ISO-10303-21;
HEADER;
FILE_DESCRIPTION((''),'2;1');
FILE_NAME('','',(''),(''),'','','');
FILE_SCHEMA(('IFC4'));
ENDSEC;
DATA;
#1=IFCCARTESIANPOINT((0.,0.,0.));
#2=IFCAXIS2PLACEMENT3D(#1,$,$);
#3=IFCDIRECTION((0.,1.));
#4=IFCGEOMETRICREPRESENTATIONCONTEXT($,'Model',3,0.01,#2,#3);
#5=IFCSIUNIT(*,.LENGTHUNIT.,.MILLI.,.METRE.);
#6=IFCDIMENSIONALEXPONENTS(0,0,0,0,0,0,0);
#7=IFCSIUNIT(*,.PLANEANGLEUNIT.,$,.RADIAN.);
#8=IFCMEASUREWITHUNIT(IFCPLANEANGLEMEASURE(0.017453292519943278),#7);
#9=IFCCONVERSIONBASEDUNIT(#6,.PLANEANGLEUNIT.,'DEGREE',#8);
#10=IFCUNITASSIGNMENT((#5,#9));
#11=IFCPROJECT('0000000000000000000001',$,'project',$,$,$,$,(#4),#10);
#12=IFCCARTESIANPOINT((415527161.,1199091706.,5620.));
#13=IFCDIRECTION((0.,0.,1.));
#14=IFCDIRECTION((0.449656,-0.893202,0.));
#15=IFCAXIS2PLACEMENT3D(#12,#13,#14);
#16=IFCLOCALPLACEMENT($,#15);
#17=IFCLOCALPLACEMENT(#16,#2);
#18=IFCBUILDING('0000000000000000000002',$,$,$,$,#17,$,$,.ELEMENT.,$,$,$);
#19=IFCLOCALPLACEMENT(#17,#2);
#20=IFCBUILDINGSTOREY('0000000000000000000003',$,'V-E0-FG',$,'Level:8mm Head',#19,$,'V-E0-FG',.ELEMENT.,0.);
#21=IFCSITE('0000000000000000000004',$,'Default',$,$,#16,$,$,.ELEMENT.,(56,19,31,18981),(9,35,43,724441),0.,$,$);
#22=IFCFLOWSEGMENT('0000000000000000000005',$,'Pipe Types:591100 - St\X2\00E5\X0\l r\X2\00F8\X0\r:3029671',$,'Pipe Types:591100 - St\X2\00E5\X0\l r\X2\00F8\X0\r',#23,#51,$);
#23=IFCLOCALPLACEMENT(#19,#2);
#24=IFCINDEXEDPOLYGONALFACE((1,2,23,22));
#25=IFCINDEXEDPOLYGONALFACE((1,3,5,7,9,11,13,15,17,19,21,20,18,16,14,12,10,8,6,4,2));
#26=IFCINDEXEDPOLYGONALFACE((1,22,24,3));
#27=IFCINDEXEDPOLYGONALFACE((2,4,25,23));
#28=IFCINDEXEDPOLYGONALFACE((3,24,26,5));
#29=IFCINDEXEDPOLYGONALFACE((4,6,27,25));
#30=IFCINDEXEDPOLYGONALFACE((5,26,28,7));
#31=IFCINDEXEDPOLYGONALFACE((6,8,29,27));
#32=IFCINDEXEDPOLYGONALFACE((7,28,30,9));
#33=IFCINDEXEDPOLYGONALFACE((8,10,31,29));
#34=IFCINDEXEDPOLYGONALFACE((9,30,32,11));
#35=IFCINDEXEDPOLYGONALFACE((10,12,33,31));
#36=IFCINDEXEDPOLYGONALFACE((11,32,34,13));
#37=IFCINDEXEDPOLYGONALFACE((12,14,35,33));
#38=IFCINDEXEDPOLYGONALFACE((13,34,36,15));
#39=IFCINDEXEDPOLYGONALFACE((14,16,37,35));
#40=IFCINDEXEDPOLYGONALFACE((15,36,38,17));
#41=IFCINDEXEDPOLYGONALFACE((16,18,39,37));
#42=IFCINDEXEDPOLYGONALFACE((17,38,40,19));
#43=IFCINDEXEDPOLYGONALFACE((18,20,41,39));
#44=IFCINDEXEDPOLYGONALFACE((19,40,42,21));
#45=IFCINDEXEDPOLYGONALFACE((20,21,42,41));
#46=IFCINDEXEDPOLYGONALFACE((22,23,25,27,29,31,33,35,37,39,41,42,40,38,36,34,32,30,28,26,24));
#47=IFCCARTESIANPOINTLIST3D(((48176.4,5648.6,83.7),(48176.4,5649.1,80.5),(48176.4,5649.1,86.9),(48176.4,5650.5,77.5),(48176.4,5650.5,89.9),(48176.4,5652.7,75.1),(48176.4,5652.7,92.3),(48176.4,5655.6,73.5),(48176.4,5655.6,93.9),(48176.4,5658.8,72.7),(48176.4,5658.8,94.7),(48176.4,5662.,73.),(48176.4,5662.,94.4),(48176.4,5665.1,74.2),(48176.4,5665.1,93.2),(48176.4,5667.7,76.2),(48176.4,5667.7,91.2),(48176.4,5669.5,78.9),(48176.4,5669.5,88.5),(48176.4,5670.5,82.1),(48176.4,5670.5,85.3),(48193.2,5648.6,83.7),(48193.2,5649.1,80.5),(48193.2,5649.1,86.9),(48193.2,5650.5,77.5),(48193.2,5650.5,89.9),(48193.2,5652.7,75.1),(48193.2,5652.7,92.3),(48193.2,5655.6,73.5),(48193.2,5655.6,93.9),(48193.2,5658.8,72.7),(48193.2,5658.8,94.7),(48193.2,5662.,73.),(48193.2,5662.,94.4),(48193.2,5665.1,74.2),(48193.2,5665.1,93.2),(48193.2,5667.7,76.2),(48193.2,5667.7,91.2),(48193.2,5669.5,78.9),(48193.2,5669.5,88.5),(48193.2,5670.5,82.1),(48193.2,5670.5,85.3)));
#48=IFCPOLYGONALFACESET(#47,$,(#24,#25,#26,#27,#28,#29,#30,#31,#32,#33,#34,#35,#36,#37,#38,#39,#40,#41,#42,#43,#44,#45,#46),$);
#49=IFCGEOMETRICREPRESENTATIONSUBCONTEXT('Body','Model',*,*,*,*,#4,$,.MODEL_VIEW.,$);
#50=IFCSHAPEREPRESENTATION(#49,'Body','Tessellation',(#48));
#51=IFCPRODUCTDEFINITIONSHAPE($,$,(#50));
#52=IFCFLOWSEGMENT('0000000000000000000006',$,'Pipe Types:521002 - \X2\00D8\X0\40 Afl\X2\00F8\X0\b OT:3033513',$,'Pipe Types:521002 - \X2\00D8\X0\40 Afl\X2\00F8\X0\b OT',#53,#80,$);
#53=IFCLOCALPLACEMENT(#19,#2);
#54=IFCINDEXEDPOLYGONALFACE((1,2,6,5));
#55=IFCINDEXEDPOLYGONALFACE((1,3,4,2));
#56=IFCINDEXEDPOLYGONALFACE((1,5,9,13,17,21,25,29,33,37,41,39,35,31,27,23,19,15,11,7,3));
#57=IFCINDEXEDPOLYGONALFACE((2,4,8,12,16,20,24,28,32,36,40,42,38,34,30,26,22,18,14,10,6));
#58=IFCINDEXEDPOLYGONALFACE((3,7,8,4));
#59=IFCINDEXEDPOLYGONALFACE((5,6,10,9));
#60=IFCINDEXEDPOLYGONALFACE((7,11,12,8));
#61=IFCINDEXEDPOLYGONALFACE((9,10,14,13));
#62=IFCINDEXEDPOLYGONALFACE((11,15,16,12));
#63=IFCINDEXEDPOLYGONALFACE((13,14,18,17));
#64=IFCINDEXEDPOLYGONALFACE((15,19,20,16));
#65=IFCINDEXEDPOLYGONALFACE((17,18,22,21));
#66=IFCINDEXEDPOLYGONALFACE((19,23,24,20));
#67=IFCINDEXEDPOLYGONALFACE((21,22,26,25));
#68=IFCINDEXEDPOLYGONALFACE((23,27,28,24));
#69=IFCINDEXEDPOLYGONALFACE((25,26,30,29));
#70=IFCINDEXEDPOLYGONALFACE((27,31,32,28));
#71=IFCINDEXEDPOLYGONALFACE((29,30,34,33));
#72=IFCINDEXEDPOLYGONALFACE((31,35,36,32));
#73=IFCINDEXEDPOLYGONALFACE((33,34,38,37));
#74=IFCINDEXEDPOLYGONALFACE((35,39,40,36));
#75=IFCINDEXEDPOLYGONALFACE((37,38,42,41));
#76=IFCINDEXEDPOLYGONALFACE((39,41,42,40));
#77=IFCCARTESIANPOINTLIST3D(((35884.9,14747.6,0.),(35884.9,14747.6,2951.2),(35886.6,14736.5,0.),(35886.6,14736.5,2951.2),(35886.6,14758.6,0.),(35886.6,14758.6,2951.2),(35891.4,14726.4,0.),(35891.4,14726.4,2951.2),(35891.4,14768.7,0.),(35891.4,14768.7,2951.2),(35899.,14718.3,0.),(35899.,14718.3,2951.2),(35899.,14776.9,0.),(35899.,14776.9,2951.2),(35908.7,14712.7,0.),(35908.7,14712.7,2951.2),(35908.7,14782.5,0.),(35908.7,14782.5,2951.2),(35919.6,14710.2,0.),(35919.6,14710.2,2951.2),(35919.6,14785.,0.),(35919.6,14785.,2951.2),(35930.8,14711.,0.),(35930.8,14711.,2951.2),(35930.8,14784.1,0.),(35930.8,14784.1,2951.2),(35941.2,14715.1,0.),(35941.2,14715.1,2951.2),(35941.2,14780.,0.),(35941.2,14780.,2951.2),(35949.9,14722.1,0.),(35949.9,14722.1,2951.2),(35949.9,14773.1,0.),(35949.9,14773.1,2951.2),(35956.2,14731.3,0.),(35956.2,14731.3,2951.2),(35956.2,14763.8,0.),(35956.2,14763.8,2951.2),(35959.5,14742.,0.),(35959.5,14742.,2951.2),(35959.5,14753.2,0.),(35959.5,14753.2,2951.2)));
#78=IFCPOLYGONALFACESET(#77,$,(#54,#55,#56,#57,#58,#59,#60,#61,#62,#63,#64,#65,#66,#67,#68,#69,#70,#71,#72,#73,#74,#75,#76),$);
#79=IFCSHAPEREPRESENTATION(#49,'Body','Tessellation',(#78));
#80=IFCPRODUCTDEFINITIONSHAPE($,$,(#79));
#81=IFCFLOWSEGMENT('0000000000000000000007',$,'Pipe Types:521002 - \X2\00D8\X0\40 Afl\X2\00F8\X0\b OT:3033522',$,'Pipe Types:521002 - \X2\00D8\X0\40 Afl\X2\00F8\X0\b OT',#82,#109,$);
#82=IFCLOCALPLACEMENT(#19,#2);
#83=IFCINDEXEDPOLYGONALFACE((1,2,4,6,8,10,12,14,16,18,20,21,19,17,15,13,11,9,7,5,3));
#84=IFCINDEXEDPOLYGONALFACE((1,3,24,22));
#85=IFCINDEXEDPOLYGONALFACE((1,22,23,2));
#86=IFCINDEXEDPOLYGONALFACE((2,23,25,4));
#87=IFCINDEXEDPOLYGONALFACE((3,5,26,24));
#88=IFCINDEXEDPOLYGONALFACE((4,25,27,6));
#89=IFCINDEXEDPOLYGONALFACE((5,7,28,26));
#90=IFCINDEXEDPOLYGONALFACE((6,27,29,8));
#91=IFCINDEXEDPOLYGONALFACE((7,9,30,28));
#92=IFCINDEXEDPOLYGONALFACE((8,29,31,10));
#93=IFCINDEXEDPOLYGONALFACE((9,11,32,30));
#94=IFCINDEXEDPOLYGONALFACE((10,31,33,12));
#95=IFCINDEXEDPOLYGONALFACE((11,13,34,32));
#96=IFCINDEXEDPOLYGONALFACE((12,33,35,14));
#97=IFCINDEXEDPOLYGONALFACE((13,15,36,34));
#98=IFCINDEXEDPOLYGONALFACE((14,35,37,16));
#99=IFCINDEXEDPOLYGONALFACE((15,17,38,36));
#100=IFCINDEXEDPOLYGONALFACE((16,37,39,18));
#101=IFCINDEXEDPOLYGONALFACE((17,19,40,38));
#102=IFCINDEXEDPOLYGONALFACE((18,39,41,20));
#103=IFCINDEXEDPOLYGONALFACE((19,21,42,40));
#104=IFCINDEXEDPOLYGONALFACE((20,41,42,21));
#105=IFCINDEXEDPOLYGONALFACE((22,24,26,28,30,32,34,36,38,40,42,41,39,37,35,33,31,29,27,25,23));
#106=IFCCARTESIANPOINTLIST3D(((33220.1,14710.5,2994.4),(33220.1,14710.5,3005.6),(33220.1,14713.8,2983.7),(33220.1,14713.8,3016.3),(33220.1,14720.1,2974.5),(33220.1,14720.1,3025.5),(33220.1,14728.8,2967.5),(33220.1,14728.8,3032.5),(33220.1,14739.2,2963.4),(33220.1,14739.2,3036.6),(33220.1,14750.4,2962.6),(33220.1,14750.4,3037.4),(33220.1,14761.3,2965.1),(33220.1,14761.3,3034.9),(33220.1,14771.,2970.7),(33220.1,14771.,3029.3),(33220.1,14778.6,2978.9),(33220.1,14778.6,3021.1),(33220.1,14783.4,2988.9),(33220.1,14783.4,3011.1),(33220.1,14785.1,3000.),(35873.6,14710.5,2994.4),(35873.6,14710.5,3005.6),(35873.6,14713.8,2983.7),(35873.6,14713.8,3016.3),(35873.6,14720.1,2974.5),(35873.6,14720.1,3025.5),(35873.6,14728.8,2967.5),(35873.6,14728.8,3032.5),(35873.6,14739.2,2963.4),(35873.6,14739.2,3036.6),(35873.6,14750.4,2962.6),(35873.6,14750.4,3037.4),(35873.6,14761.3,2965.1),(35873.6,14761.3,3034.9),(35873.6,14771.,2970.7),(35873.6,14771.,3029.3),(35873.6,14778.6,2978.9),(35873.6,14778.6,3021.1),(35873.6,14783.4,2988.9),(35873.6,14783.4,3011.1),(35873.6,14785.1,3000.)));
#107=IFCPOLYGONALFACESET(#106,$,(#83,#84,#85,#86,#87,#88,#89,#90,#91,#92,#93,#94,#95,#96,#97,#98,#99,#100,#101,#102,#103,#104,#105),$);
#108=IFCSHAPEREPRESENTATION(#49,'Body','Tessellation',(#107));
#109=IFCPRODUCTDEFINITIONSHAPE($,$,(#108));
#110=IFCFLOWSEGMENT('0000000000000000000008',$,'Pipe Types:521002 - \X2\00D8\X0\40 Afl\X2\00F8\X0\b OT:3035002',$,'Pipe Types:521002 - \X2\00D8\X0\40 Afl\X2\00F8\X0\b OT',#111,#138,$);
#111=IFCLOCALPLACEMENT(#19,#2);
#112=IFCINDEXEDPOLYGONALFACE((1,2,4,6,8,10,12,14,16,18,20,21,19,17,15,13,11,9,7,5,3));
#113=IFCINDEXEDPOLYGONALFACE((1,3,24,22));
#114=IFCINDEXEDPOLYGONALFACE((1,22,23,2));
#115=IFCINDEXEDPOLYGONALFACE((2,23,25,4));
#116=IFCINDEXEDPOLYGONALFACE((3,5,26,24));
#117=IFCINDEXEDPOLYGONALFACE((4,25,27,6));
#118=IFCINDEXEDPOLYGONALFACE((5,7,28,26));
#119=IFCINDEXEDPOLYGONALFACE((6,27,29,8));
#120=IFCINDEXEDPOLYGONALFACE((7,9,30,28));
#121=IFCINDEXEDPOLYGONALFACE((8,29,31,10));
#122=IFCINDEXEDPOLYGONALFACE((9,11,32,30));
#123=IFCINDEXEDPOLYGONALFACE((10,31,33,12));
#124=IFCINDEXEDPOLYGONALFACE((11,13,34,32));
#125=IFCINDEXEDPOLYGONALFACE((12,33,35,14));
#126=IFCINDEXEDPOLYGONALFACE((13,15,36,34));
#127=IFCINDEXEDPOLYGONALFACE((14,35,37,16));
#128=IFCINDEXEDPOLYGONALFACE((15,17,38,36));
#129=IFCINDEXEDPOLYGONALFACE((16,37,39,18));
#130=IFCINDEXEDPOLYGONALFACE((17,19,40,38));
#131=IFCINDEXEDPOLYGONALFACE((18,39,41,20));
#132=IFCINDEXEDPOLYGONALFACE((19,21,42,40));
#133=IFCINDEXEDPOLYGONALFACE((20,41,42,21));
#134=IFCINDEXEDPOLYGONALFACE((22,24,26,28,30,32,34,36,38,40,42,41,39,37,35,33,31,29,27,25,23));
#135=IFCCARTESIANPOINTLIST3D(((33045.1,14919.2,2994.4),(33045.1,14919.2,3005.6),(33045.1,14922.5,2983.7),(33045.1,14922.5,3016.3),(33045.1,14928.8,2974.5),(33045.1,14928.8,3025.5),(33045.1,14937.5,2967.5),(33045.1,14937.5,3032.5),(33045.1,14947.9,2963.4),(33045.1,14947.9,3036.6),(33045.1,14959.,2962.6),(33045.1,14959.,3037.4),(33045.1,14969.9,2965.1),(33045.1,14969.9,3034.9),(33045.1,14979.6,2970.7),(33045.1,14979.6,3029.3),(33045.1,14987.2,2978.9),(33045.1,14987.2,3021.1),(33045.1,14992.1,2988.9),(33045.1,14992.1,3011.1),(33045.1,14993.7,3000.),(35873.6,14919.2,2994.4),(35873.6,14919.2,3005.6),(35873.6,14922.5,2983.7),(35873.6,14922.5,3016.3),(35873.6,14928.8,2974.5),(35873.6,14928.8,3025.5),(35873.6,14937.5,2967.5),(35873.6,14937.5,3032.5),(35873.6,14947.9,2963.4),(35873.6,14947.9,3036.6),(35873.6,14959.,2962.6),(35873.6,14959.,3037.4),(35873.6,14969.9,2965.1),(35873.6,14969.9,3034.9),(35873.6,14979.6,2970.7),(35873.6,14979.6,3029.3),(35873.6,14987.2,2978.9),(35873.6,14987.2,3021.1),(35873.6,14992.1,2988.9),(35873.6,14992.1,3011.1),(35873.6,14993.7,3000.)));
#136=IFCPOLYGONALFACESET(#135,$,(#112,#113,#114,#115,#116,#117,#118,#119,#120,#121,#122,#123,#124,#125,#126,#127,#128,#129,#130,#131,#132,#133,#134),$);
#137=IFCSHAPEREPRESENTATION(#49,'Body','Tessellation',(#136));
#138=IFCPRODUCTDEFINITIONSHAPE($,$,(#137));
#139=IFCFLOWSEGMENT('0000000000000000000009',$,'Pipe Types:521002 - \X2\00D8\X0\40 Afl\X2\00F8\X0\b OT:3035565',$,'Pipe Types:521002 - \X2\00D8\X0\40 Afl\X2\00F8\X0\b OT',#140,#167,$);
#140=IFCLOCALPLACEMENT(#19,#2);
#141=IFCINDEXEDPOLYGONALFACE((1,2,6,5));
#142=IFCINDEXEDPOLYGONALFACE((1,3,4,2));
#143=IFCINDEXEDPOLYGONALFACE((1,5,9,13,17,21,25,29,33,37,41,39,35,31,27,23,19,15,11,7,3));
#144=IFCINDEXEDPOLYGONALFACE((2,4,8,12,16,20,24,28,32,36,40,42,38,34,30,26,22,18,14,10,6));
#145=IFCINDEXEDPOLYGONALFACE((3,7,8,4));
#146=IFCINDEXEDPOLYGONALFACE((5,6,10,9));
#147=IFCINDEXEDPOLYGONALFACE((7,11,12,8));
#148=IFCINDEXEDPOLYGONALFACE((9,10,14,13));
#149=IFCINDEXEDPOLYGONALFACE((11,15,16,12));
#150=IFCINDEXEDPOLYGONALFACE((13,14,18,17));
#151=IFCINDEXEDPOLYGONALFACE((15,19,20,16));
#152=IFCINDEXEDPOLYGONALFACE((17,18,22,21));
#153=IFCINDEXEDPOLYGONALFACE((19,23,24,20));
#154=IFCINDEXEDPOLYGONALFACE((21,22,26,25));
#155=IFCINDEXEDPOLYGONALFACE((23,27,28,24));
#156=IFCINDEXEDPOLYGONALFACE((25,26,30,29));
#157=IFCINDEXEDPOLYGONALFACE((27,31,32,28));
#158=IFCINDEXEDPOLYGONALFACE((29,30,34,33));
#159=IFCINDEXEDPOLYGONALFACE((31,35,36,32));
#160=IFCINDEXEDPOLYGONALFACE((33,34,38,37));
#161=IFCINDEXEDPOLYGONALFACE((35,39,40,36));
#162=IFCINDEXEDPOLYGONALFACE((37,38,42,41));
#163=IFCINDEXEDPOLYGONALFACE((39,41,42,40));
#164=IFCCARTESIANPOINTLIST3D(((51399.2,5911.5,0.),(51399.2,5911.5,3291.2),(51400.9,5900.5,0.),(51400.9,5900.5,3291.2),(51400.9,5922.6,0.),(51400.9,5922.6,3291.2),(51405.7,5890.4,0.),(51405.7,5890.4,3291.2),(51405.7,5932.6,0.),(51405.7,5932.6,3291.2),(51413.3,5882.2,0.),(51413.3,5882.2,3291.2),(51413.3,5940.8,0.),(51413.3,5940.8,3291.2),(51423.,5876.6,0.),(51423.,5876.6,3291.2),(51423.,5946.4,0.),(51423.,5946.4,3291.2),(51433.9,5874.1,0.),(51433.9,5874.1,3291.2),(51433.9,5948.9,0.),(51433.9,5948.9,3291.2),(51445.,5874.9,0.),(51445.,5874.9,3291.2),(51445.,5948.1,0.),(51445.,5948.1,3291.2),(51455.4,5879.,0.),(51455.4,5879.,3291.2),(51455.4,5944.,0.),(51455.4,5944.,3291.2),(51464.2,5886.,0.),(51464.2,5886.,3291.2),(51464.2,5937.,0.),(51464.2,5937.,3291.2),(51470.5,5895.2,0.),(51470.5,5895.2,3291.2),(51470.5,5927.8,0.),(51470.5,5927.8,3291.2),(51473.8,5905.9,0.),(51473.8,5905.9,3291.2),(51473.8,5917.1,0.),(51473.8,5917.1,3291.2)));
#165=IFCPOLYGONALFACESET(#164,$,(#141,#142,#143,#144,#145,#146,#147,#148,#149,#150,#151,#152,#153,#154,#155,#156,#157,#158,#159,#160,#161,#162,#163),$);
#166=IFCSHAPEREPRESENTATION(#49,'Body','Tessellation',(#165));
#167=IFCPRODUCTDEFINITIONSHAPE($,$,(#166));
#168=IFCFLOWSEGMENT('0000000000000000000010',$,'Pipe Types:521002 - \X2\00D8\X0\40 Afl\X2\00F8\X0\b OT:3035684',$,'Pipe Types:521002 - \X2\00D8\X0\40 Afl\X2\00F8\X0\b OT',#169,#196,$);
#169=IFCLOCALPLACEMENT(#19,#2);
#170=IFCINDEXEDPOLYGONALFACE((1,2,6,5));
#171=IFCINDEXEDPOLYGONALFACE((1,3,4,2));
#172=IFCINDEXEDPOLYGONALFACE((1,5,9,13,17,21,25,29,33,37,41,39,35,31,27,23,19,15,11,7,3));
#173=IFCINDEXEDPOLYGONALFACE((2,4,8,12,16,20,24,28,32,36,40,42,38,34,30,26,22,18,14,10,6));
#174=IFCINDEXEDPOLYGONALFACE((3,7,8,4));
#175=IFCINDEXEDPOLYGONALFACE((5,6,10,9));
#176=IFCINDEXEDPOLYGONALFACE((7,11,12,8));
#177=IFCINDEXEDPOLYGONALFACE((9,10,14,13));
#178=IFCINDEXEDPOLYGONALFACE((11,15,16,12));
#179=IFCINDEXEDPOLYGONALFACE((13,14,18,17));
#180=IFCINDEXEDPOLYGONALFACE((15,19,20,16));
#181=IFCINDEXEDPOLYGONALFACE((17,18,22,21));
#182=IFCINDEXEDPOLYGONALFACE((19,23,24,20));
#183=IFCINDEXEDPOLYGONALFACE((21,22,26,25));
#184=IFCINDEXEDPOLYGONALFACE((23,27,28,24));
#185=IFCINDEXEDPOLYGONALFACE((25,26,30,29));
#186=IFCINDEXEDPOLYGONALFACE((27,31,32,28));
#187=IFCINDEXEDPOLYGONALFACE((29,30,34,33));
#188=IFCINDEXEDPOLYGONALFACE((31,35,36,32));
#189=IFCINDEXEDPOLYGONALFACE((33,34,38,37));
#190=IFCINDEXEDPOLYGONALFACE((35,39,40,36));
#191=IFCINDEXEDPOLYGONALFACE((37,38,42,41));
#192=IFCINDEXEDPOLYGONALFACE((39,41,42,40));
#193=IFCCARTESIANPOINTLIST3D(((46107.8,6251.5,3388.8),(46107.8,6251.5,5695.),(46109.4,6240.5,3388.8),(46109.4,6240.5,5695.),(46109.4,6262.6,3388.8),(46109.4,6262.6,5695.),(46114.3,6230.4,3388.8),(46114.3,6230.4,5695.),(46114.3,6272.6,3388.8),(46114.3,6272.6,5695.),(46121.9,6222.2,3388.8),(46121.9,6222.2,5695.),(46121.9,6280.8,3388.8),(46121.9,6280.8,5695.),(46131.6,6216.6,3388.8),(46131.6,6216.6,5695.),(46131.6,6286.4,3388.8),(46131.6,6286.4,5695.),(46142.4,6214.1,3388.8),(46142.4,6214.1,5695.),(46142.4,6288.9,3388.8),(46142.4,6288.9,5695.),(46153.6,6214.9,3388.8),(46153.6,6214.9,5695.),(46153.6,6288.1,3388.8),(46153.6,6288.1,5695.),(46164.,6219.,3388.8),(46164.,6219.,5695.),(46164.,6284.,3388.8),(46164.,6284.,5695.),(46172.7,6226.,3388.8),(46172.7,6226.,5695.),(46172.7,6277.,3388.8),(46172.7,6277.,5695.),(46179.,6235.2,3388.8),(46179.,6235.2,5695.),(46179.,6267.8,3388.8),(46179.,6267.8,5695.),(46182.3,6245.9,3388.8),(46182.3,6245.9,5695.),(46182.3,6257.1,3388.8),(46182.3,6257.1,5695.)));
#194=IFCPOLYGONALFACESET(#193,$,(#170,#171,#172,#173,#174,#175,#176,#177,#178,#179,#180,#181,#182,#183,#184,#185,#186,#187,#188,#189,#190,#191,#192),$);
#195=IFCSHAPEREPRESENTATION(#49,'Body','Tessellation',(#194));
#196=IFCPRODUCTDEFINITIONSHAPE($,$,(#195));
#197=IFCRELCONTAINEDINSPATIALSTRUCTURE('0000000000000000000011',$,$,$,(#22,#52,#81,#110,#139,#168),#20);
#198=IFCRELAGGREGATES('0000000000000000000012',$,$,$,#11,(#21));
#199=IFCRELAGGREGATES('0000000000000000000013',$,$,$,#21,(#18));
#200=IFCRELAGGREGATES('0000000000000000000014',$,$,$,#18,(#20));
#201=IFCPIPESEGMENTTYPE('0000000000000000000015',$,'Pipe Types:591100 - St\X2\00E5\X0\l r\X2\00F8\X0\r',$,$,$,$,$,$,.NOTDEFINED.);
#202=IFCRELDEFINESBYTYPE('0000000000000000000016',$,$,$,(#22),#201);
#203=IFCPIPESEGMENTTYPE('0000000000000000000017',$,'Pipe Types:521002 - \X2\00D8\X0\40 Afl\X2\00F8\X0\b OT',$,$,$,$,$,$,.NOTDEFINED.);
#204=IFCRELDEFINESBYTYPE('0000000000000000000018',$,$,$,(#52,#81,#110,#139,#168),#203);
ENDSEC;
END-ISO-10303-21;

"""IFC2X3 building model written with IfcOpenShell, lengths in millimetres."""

from ifc_helpers import new_model, entity, si_unit, converted_unit, direction, frame, frame_2d, origin, origin_2d_with_axis, place, context, subcontext, project, spatial, circle, extrude, type_object, element, save


model = new_model("IFC2X3")

# Units and contexts
model_context = context("Model", 3, precision=0.01, world=origin(), true_north=direction((0.0, 1.0)))
body_context = subcontext(model_context, "Body", "Model", "MODEL_VIEW")
ifc_project = project(units=[si_unit("LENGTHUNIT", "METRE", prefix="MILLI"), converted_unit("PLANEANGLEUNIT", "DEGREE", entity("IfcPlaneAngleMeasure", 0.017453292519943278), si_unit("PLANEANGLEUNIT", "RADIAN"), dimensions=[0, 0, 0, 0, 0, 0, 0])], contexts=[model_context])

# Site, building, storey
site_placement = place(None, frame((415527161.0, 1199091706.0, 5620.0), z_axis=(0.0, 0.0, 1.0), x_axis=(0.449656, -0.893202, 0.0)))
site = spatial("IfcSite", under=ifc_project, at=site_placement, Name="Default", CompositionType="ELEMENT", RefLatitude=(56, 19, 31, 18981), RefLongitude=(9, 35, 43, 724441), RefElevation=0.0)
building_placement = place(site_placement, origin())
building = spatial("IfcBuilding", under=site, at=building_placement, CompositionType="ELEMENT")
storey_placement = place(building_placement, origin())
storey = spatial("IfcBuildingStorey", under=building, at=storey_placement, Name="V-E0-FG", ObjectType="Level:8mm Head", LongName="V-E0-FG", CompositionType="ELEMENT", Elevation=0.0)

# Flow segments
pipe_segment_type_1 = type_object("IfcPipeSegmentType", Name="Pipe Types:591100 - Stål rør", PredefinedType="NOTDEFINED")
flow_segment_1_placement = place(storey_placement, origin())
element("IfcFlowSegment", 1, at=flow_segment_1_placement, inside=storey, type_object=pipe_segment_type_1, Name="Pipe Types:591100 - Stål rør:3029671", ObjectType="Pipe Types:591100 - Stål rør", context=body_context, shape_type="SweptSolid", body=[
    extrude(circle(Radius=11.0, at=origin_2d_with_axis()), frame((48176.4, 5659.6, 83.7), z_axis=(1.0, 0.0, 0.0), x_axis=(0.0, -1.0, 0.0)), (0.0, 0.0, 1.0), 16.8),
])
pipe_segment_type_2 = type_object("IfcPipeSegmentType", Name="Pipe Types:521002 - Ø40 Afløb OT", PredefinedType="NOTDEFINED")
flow_segment_2_placement = place(storey_placement, origin())
element("IfcFlowSegment", 2, at=flow_segment_2_placement, inside=storey, type_object=pipe_segment_type_2, Name="Pipe Types:521002 - Ø40 Afløb OT:3033513", ObjectType="Pipe Types:521002 - Ø40 Afløb OT", context=body_context, shape_type="SweptSolid", body=[
    extrude(circle(Radius=37.5, at=origin_2d_with_axis()), frame((35922.4, 14747.6, 0.0), z_axis=(0.0, 0.0, 1.0), x_axis=(-1.0, 0.0, 0.0)), (0.0, 0.0, 1.0), 2951.2),
])
flow_segment_3_placement = place(storey_placement, origin())
element("IfcFlowSegment", 3, at=flow_segment_3_placement, inside=storey, type_object=pipe_segment_type_2, Name="Pipe Types:521002 - Ø40 Afløb OT:3033522", ObjectType="Pipe Types:521002 - Ø40 Afløb OT", context=body_context, shape_type="SweptSolid", body=[
    extrude(circle(Radius=37.5, at=frame_2d((0.0, 0.0), x_axis=(1.0, 0.0))), frame((33220.1, 14747.6, 3000.0), z_axis=(1.0, 0.0, 0.0), x_axis=(0.0, 1.0, 0.0)), (0.0, 0.0, 1.0), 2653.4),
])
flow_segment_4_placement = place(storey_placement, origin())
element("IfcFlowSegment", 4, at=flow_segment_4_placement, inside=storey, type_object=pipe_segment_type_2, Name="Pipe Types:521002 - Ø40 Afløb OT:3035002", ObjectType="Pipe Types:521002 - Ø40 Afløb OT", context=body_context, shape_type="SweptSolid", body=[
    extrude(circle(Radius=37.5, at=frame_2d((0.0, 0.0), x_axis=(1.0, 0.0))), frame((33045.1, 14956.2, 3000.0), z_axis=(1.0, 0.0, 0.0), x_axis=(0.0, 1.0, 0.0)), (0.0, 0.0, 1.0), 2828.4),
])
flow_segment_5_placement = place(storey_placement, origin())
element("IfcFlowSegment", 5, at=flow_segment_5_placement, inside=storey, type_object=pipe_segment_type_2, Name="Pipe Types:521002 - Ø40 Afløb OT:3035565", ObjectType="Pipe Types:521002 - Ø40 Afløb OT", context=body_context, shape_type="SweptSolid", body=[
    extrude(circle(Radius=37.5, at=origin_2d_with_axis()), frame((51436.7, 5911.5, 0.0), z_axis=(0.0, 0.0, 1.0), x_axis=(-1.0, 0.0, 0.0)), (0.0, 0.0, 1.0), 3291.2),
])
flow_segment_6_placement = place(storey_placement, origin())
element("IfcFlowSegment", 6, at=flow_segment_6_placement, inside=storey, type_object=pipe_segment_type_2, Name="Pipe Types:521002 - Ø40 Afløb OT:3035684", ObjectType="Pipe Types:521002 - Ø40 Afløb OT", context=body_context, shape_type="SweptSolid", body=[
    extrude(circle(Radius=37.5, at=origin_2d_with_axis()), frame((46145.3, 6251.5, 3388.8), z_axis=(0.0, 0.0, 1.0), x_axis=(-1.0, 0.0, 0.0)), (0.0, 0.0, 1.0), 2306.2),
])

save(model, "model.ifc")
